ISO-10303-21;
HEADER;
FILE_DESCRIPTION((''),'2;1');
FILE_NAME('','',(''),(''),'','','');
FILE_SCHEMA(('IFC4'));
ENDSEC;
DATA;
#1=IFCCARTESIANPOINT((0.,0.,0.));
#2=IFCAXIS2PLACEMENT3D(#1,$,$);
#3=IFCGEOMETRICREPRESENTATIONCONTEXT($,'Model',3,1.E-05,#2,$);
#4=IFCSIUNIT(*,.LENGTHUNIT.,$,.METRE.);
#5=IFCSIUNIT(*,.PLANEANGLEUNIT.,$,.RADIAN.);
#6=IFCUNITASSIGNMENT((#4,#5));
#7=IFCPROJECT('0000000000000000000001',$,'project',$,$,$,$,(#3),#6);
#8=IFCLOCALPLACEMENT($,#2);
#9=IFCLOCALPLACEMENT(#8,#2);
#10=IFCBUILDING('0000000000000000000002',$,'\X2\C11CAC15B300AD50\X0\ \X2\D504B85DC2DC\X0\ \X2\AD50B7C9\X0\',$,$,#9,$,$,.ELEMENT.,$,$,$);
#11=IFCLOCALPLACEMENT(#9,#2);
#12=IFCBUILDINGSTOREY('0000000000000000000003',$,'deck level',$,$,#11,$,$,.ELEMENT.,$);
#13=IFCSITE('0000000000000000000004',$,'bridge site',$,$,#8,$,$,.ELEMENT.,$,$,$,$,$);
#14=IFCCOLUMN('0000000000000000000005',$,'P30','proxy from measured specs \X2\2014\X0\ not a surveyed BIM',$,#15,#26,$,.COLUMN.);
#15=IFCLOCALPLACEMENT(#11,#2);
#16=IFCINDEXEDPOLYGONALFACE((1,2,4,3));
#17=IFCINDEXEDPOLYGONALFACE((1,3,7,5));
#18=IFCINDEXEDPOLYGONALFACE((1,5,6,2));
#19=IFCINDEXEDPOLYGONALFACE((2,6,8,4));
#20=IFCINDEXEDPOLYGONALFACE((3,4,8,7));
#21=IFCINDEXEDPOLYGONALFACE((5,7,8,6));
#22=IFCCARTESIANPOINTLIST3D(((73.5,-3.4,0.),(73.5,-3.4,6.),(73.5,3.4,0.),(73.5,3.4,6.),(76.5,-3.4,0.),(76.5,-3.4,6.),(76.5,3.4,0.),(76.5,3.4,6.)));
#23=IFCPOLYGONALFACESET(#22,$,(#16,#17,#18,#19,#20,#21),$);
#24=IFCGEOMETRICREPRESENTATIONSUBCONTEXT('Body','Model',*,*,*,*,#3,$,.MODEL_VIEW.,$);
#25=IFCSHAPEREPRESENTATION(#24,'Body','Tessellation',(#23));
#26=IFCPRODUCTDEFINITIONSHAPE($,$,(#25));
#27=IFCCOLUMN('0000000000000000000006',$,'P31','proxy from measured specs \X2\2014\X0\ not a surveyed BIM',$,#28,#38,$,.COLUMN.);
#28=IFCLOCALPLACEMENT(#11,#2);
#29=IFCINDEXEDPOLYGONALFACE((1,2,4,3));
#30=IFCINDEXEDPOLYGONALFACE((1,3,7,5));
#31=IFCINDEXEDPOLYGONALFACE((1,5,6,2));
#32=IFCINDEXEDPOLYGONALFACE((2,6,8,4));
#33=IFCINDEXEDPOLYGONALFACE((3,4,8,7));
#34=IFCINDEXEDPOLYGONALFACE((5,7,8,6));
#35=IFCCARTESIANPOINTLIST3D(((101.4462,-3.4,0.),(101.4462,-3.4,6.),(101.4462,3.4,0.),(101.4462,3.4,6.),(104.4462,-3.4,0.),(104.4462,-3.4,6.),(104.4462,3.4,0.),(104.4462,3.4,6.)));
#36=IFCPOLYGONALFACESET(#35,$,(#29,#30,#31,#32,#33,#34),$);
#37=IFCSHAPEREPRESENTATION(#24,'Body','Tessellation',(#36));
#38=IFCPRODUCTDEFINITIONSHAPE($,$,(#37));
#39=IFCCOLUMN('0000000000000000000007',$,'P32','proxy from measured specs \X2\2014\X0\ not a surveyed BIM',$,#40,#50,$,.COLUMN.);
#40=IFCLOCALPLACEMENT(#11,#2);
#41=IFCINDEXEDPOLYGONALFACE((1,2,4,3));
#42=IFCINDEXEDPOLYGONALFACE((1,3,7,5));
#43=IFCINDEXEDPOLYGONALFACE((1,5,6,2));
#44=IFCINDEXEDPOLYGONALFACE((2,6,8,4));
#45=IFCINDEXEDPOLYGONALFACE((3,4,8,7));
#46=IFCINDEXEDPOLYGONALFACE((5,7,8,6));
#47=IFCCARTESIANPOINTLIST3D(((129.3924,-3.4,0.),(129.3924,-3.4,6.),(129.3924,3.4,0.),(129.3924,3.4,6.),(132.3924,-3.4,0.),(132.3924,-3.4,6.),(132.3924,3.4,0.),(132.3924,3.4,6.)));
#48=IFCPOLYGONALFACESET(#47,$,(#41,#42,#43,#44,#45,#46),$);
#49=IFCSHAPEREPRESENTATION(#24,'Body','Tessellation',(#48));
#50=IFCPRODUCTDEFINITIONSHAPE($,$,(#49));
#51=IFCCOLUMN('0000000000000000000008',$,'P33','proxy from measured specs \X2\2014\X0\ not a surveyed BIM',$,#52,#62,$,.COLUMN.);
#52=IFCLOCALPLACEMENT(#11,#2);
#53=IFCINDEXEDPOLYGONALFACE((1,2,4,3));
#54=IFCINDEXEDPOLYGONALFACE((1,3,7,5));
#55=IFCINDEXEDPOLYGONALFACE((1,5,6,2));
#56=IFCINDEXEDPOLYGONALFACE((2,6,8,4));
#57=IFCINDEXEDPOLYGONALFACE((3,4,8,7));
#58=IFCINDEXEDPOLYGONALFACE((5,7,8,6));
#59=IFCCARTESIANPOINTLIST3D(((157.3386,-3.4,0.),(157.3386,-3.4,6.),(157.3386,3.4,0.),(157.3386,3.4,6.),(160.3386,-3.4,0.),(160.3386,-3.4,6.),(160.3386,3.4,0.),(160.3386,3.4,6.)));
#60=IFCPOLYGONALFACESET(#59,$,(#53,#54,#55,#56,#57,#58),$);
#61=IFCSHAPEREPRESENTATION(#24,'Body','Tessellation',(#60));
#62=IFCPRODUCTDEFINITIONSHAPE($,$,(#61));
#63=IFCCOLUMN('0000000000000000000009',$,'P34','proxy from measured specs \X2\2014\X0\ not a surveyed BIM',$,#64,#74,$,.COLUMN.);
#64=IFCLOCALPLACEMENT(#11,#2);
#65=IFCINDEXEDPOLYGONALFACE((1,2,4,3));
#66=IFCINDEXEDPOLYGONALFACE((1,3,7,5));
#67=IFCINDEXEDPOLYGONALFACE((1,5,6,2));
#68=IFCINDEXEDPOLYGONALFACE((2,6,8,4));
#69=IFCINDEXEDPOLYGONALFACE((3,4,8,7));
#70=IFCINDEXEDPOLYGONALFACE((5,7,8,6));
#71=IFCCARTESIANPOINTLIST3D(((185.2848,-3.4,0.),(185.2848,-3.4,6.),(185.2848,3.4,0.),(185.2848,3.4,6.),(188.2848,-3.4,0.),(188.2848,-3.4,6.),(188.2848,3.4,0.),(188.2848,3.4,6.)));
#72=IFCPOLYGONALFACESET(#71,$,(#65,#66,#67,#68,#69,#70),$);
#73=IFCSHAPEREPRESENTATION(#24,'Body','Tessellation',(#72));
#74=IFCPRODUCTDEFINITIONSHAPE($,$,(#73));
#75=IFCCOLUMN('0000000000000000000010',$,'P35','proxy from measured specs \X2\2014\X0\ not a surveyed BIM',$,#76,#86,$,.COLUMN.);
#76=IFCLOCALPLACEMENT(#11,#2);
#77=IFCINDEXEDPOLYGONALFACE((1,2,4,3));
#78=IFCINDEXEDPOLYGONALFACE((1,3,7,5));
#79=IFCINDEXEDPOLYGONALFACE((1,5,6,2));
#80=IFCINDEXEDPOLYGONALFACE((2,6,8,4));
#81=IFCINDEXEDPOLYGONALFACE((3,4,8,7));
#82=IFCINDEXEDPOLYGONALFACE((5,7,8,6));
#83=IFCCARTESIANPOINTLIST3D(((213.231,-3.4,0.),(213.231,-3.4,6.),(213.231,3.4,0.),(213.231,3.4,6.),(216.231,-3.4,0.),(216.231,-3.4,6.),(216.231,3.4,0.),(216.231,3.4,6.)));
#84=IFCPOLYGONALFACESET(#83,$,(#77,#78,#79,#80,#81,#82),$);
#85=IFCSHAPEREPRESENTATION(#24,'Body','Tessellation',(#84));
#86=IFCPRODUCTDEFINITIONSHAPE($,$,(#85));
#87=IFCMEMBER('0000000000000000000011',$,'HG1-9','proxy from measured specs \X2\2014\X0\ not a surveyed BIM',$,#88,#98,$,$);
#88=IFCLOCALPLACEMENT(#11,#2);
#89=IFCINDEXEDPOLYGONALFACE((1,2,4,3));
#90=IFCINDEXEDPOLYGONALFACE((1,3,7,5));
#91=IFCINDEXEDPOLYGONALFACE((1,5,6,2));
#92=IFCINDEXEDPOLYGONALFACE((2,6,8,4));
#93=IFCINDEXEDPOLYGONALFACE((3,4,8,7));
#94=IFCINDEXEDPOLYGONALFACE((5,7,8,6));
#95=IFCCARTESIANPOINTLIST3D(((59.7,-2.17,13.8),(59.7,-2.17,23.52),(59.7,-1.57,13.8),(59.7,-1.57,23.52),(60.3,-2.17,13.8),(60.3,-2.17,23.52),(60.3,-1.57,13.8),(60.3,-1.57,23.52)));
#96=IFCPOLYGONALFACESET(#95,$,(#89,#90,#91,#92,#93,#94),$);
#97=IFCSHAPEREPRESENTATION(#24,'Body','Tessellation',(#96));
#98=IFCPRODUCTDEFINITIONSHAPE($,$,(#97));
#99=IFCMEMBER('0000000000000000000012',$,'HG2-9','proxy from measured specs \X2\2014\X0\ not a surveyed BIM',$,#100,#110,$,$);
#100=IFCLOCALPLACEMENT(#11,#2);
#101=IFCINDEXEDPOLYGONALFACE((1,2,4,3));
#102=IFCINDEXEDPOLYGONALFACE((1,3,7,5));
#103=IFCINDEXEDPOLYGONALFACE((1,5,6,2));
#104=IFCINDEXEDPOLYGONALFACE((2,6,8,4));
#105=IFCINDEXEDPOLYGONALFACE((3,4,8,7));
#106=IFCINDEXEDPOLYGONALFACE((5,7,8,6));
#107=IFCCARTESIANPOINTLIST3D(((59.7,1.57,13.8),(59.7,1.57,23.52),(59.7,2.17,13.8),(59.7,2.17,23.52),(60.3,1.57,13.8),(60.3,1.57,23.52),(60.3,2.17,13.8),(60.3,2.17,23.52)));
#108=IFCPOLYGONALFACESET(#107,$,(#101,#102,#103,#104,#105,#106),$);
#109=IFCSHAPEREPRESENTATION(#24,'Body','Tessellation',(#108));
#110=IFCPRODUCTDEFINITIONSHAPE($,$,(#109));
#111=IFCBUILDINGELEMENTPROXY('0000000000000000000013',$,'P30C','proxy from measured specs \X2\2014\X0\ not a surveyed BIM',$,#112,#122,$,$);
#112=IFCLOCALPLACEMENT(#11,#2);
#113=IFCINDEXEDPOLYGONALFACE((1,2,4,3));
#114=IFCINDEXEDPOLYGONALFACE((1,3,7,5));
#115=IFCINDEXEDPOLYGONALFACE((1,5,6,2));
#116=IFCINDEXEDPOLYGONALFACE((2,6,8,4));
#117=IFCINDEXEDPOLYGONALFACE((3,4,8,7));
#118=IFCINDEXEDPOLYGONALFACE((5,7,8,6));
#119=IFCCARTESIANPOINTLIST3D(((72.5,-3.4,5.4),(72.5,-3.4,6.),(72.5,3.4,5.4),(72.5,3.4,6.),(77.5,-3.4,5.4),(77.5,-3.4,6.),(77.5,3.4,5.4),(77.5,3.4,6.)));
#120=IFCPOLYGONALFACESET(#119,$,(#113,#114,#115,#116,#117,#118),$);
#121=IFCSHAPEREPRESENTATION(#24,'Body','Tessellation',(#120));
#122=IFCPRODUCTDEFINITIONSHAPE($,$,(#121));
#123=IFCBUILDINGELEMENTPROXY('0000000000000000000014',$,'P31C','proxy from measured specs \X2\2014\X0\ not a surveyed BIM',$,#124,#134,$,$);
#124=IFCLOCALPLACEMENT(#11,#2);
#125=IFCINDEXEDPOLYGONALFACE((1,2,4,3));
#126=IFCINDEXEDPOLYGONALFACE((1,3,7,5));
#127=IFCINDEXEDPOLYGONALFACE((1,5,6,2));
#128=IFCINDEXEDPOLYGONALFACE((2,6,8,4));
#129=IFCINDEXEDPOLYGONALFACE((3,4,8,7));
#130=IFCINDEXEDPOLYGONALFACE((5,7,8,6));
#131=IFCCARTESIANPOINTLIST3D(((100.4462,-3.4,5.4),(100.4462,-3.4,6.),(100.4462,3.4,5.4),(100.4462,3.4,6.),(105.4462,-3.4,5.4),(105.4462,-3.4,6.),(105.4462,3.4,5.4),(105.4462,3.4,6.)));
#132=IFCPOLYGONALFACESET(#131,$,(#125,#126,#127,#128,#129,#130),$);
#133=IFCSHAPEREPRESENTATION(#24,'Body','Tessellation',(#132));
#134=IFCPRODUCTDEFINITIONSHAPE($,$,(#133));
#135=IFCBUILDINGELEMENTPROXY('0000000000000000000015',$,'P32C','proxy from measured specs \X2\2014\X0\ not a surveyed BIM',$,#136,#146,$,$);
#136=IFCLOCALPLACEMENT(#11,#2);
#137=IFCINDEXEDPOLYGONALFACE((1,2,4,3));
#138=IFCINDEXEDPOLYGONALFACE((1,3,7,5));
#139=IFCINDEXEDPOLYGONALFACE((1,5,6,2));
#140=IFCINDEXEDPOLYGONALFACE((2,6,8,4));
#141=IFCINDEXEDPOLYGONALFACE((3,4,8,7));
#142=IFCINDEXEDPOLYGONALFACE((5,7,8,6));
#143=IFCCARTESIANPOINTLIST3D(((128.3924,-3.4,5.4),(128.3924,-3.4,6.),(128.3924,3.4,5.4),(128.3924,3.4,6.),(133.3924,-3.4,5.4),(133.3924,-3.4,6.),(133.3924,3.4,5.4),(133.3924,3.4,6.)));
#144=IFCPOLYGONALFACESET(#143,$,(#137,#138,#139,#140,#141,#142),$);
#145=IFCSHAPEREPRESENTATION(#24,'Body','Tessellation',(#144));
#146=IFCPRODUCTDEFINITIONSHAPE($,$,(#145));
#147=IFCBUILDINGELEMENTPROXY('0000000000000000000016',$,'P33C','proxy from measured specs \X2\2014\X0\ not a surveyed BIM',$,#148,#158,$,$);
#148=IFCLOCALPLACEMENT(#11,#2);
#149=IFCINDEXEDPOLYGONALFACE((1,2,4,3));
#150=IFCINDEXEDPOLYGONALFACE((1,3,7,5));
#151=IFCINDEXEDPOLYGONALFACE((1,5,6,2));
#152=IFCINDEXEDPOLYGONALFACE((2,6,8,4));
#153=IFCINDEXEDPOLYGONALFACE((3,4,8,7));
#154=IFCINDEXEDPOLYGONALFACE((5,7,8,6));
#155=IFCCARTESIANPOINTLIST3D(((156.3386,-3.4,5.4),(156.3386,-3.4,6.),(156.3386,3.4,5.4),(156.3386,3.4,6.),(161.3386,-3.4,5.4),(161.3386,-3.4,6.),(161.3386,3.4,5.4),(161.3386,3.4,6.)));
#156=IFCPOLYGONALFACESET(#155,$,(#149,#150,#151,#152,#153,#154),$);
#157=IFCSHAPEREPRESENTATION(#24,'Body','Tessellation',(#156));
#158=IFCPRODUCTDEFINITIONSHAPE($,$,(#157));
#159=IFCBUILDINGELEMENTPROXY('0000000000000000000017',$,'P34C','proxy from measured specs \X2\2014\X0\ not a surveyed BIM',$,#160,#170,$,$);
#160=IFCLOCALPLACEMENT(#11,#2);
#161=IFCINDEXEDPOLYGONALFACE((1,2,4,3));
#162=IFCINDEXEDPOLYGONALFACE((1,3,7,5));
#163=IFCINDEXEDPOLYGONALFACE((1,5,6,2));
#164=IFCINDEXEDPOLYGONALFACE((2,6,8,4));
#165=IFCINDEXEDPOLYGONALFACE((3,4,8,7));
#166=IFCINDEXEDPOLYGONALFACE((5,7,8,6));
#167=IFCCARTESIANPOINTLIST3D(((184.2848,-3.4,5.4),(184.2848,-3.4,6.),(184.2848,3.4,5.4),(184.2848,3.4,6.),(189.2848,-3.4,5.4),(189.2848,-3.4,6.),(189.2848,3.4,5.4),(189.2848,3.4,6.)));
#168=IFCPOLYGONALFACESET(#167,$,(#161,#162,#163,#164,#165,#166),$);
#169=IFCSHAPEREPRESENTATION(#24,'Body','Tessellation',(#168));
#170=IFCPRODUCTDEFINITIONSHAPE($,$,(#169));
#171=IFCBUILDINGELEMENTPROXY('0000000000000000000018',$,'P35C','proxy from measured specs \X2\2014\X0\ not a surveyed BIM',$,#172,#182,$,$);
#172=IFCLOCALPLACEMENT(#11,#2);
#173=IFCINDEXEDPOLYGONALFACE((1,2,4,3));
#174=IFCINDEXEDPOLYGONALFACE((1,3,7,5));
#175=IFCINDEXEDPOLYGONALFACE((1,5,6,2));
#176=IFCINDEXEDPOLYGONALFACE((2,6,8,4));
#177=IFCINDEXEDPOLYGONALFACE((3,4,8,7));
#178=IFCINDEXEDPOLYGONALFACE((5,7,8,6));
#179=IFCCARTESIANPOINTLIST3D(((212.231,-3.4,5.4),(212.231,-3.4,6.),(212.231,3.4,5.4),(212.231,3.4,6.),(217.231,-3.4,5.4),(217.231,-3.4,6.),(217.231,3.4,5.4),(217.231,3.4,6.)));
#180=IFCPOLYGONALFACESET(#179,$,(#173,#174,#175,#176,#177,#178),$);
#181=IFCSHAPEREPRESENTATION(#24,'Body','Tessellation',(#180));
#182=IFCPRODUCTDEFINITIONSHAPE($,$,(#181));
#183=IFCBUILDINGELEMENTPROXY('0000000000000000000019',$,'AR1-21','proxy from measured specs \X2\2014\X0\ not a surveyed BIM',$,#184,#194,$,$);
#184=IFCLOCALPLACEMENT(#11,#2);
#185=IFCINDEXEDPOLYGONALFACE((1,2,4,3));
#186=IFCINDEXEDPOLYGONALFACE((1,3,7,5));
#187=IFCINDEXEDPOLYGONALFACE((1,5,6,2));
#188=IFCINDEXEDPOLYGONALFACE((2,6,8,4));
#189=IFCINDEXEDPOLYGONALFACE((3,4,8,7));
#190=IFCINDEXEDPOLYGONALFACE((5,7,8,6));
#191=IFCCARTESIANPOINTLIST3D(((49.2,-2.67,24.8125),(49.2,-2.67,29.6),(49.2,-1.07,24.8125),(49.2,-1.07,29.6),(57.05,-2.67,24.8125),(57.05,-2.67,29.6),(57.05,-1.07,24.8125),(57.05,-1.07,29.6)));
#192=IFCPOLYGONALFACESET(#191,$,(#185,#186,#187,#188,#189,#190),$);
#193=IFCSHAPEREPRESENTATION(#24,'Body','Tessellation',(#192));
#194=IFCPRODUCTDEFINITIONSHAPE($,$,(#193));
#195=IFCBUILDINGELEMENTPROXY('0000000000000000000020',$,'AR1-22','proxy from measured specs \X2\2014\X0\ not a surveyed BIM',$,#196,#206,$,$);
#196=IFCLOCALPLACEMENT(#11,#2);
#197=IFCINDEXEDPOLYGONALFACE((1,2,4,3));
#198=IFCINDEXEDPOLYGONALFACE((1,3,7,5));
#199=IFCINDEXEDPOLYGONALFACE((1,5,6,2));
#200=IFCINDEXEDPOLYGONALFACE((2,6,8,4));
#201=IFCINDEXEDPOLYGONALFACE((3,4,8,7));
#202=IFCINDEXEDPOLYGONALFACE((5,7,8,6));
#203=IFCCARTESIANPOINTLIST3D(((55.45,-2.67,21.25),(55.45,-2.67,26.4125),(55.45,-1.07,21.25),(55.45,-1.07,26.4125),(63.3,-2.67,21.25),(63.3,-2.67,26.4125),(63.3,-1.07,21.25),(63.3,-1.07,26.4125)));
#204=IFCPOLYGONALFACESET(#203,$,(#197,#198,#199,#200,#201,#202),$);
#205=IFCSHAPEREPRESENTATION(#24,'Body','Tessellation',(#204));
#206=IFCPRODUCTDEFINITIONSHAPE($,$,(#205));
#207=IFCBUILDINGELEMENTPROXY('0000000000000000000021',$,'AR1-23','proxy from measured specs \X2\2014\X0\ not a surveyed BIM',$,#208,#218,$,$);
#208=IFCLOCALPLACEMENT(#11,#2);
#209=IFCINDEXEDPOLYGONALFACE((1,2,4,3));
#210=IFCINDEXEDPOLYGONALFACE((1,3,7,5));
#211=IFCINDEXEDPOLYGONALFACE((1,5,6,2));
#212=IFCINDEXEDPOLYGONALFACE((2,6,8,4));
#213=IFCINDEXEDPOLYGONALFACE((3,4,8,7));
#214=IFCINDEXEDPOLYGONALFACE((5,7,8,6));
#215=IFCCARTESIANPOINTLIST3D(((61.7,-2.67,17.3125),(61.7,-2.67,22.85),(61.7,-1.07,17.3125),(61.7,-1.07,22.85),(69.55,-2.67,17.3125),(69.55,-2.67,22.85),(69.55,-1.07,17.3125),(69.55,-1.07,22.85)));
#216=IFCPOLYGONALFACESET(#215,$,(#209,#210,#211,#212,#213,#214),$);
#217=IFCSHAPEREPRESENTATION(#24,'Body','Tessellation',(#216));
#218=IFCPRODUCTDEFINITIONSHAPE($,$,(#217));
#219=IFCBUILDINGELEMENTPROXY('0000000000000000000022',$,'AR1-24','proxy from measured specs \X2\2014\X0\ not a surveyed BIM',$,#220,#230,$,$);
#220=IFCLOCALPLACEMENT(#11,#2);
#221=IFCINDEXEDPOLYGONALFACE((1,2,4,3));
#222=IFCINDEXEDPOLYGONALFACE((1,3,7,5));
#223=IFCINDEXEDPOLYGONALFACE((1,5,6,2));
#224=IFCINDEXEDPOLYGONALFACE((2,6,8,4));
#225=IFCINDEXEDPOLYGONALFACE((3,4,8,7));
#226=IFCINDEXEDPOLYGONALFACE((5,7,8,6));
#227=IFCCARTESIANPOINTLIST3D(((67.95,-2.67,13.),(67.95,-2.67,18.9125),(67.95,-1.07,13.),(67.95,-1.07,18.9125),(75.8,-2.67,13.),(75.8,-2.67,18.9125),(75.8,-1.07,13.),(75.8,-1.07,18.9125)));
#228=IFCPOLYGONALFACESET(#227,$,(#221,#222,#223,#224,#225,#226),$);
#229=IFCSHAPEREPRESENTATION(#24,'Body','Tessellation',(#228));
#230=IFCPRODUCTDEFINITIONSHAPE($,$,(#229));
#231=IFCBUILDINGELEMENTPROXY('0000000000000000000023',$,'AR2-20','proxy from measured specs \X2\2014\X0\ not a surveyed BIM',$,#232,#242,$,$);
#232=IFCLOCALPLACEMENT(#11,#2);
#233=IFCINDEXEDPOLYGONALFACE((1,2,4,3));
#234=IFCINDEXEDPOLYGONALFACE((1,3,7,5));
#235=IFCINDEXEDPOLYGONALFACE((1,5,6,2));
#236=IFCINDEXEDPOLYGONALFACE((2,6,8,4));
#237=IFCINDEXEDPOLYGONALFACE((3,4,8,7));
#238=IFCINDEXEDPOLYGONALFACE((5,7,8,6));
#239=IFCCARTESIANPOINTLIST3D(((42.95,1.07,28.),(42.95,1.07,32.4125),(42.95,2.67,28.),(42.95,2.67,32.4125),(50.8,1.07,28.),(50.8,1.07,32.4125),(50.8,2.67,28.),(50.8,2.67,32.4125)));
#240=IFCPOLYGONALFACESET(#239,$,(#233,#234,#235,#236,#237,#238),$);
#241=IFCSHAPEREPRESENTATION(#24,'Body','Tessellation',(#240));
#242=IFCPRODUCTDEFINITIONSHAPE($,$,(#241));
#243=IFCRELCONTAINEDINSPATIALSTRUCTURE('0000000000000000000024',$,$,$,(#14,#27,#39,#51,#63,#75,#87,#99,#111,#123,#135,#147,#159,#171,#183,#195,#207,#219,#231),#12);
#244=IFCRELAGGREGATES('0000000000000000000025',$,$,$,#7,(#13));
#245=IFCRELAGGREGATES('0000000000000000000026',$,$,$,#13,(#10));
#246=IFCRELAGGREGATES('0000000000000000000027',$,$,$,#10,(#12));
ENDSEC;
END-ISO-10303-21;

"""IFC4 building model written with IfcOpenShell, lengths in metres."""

from ifc_helpers import new_model, si_unit, frame, origin, origin_2d, place, context, subcontext, project, spatial, rectangle, extrude, element, save


model = new_model("IFC4")

# Units and contexts
model_context = context("Model", 3, precision=1e-05, world=origin())
body_context = subcontext(model_context, "Body", "Model", "MODEL_VIEW")
ifc_project = project(units=[si_unit("LENGTHUNIT", "METRE"), si_unit("PLANEANGLEUNIT", "RADIAN")], contexts=[model_context])

# Site, building, storey
site_placement = place(None, origin())
site = spatial("IfcSite", under=ifc_project, at=site_placement, Name="bridge site", CompositionType="ELEMENT")
building_placement = place(site_placement, origin())
building = spatial("IfcBuilding", under=site, at=building_placement, Name="서강대교 프록시 교량", CompositionType="ELEMENT")
storey_placement = place(building_placement, origin())
storey = spatial("IfcBuildingStorey", under=building, at=storey_placement, Name="deck level", CompositionType="ELEMENT")

# Columns
for number, where, name in (
    (1, (75.0, 0.0, 0.0), "P30"),
    (2, (102.9462, 0.0, 0.0), "P31"),
    (3, (130.8924, 0.0, 0.0), "P32"),
    (4, (158.8386, 0.0, 0.0), "P33"),
    (5, (186.7848, 0.0, 0.0), "P34"),
    (6, (214.731, 0.0, 0.0), "P35"),
):
    element("IfcColumn", number, at=place(storey_placement, frame(where)), inside=storey, Name=name, Description="proxy from measured specs — not a surveyed BIM", PredefinedType="COLUMN", context=body_context, shape_type="SweptSolid", body=[
        extrude(rectangle(XDim=3.0, YDim=6.8, at=origin_2d()), origin(), (0.0, 0.0, 1.0), 6.0),
    ])

# Members
for number, where, name in (
    (7, (60.0, -1.87, 13.8), "HG1-9"),
    (8, (60.0, 1.87, 13.8), "HG2-9"),
):
    element("IfcMember", number, at=place(storey_placement, frame(where)), inside=storey, Name=name, Description="proxy from measured specs — not a surveyed BIM", context=body_context, shape_type="SweptSolid", body=[
        extrude(rectangle(XDim=0.6, YDim=0.6, at=origin_2d()), origin(), (0.0, 0.0, 1.0), 9.72),
    ])

# Building element proxies
for number, where, name in (
    (9, (75.0, 0.0, 5.4), "P30C"),
    (10, (102.9462, 0.0, 5.4), "P31C"),
    (11, (130.8924, 0.0, 5.4), "P32C"),
    (12, (158.8386, 0.0, 5.4), "P33C"),
    (13, (186.7848, 0.0, 5.4), "P34C"),
    (14, (214.731, 0.0, 5.4), "P35C"),
):
    element("IfcBuildingElementProxy", number, at=place(storey_placement, frame(where)), inside=storey, Name=name, Description="proxy from measured specs — not a surveyed BIM", context=body_context, shape_type="SweptSolid", body=[
        extrude(rectangle(XDim=5.0, YDim=6.8, at=origin_2d()), origin(), (0.0, 0.0, 1.0), 0.6),
    ])
proxy_1_placement = place(storey_placement, frame((53.125, -1.87, 24.8125)))
element("IfcBuildingElementProxy", 15, at=proxy_1_placement, inside=storey, Name="AR1-21", Description="proxy from measured specs — not a surveyed BIM", context=body_context, shape_type="SweptSolid", body=[
    extrude(rectangle(XDim=7.85, YDim=1.6, at=origin_2d()), origin(), (0.0, 0.0, 1.0), 4.7875),
])
proxy_2_placement = place(storey_placement, frame((59.375, -1.87, 21.25)))
element("IfcBuildingElementProxy", 16, at=proxy_2_placement, inside=storey, Name="AR1-22", Description="proxy from measured specs — not a surveyed BIM", context=body_context, shape_type="SweptSolid", body=[
    extrude(rectangle(XDim=7.85, YDim=1.6, at=origin_2d()), origin(), (0.0, 0.0, 1.0), 5.1625),
])
proxy_3_placement = place(storey_placement, frame((65.625, -1.87, 17.3125)))
element("IfcBuildingElementProxy", 17, at=proxy_3_placement, inside=storey, Name="AR1-23", Description="proxy from measured specs — not a surveyed BIM", context=body_context, shape_type="SweptSolid", body=[
    extrude(rectangle(XDim=7.85, YDim=1.6, at=origin_2d()), origin(), (0.0, 0.0, 1.0), 5.5375),
])
proxy_4_placement = place(storey_placement, frame((71.875, -1.87, 13.0)))
element("IfcBuildingElementProxy", 18, at=proxy_4_placement, inside=storey, Name="AR1-24", Description="proxy from measured specs — not a surveyed BIM", context=body_context, shape_type="SweptSolid", body=[
    extrude(rectangle(XDim=7.85, YDim=1.6, at=origin_2d()), origin(), (0.0, 0.0, 1.0), 5.9125),
])
proxy_5_placement = place(storey_placement, frame((46.875, 1.87, 28.0)))
element("IfcBuildingElementProxy", 19, at=proxy_5_placement, inside=storey, Name="AR2-20", Description="proxy from measured specs — not a surveyed BIM", context=body_context, shape_type="SweptSolid", body=[
    extrude(rectangle(XDim=7.85, YDim=1.6, at=origin_2d()), origin(), (0.0, 0.0, 1.0), 4.4125),
])

save(model, "model.ifc")
